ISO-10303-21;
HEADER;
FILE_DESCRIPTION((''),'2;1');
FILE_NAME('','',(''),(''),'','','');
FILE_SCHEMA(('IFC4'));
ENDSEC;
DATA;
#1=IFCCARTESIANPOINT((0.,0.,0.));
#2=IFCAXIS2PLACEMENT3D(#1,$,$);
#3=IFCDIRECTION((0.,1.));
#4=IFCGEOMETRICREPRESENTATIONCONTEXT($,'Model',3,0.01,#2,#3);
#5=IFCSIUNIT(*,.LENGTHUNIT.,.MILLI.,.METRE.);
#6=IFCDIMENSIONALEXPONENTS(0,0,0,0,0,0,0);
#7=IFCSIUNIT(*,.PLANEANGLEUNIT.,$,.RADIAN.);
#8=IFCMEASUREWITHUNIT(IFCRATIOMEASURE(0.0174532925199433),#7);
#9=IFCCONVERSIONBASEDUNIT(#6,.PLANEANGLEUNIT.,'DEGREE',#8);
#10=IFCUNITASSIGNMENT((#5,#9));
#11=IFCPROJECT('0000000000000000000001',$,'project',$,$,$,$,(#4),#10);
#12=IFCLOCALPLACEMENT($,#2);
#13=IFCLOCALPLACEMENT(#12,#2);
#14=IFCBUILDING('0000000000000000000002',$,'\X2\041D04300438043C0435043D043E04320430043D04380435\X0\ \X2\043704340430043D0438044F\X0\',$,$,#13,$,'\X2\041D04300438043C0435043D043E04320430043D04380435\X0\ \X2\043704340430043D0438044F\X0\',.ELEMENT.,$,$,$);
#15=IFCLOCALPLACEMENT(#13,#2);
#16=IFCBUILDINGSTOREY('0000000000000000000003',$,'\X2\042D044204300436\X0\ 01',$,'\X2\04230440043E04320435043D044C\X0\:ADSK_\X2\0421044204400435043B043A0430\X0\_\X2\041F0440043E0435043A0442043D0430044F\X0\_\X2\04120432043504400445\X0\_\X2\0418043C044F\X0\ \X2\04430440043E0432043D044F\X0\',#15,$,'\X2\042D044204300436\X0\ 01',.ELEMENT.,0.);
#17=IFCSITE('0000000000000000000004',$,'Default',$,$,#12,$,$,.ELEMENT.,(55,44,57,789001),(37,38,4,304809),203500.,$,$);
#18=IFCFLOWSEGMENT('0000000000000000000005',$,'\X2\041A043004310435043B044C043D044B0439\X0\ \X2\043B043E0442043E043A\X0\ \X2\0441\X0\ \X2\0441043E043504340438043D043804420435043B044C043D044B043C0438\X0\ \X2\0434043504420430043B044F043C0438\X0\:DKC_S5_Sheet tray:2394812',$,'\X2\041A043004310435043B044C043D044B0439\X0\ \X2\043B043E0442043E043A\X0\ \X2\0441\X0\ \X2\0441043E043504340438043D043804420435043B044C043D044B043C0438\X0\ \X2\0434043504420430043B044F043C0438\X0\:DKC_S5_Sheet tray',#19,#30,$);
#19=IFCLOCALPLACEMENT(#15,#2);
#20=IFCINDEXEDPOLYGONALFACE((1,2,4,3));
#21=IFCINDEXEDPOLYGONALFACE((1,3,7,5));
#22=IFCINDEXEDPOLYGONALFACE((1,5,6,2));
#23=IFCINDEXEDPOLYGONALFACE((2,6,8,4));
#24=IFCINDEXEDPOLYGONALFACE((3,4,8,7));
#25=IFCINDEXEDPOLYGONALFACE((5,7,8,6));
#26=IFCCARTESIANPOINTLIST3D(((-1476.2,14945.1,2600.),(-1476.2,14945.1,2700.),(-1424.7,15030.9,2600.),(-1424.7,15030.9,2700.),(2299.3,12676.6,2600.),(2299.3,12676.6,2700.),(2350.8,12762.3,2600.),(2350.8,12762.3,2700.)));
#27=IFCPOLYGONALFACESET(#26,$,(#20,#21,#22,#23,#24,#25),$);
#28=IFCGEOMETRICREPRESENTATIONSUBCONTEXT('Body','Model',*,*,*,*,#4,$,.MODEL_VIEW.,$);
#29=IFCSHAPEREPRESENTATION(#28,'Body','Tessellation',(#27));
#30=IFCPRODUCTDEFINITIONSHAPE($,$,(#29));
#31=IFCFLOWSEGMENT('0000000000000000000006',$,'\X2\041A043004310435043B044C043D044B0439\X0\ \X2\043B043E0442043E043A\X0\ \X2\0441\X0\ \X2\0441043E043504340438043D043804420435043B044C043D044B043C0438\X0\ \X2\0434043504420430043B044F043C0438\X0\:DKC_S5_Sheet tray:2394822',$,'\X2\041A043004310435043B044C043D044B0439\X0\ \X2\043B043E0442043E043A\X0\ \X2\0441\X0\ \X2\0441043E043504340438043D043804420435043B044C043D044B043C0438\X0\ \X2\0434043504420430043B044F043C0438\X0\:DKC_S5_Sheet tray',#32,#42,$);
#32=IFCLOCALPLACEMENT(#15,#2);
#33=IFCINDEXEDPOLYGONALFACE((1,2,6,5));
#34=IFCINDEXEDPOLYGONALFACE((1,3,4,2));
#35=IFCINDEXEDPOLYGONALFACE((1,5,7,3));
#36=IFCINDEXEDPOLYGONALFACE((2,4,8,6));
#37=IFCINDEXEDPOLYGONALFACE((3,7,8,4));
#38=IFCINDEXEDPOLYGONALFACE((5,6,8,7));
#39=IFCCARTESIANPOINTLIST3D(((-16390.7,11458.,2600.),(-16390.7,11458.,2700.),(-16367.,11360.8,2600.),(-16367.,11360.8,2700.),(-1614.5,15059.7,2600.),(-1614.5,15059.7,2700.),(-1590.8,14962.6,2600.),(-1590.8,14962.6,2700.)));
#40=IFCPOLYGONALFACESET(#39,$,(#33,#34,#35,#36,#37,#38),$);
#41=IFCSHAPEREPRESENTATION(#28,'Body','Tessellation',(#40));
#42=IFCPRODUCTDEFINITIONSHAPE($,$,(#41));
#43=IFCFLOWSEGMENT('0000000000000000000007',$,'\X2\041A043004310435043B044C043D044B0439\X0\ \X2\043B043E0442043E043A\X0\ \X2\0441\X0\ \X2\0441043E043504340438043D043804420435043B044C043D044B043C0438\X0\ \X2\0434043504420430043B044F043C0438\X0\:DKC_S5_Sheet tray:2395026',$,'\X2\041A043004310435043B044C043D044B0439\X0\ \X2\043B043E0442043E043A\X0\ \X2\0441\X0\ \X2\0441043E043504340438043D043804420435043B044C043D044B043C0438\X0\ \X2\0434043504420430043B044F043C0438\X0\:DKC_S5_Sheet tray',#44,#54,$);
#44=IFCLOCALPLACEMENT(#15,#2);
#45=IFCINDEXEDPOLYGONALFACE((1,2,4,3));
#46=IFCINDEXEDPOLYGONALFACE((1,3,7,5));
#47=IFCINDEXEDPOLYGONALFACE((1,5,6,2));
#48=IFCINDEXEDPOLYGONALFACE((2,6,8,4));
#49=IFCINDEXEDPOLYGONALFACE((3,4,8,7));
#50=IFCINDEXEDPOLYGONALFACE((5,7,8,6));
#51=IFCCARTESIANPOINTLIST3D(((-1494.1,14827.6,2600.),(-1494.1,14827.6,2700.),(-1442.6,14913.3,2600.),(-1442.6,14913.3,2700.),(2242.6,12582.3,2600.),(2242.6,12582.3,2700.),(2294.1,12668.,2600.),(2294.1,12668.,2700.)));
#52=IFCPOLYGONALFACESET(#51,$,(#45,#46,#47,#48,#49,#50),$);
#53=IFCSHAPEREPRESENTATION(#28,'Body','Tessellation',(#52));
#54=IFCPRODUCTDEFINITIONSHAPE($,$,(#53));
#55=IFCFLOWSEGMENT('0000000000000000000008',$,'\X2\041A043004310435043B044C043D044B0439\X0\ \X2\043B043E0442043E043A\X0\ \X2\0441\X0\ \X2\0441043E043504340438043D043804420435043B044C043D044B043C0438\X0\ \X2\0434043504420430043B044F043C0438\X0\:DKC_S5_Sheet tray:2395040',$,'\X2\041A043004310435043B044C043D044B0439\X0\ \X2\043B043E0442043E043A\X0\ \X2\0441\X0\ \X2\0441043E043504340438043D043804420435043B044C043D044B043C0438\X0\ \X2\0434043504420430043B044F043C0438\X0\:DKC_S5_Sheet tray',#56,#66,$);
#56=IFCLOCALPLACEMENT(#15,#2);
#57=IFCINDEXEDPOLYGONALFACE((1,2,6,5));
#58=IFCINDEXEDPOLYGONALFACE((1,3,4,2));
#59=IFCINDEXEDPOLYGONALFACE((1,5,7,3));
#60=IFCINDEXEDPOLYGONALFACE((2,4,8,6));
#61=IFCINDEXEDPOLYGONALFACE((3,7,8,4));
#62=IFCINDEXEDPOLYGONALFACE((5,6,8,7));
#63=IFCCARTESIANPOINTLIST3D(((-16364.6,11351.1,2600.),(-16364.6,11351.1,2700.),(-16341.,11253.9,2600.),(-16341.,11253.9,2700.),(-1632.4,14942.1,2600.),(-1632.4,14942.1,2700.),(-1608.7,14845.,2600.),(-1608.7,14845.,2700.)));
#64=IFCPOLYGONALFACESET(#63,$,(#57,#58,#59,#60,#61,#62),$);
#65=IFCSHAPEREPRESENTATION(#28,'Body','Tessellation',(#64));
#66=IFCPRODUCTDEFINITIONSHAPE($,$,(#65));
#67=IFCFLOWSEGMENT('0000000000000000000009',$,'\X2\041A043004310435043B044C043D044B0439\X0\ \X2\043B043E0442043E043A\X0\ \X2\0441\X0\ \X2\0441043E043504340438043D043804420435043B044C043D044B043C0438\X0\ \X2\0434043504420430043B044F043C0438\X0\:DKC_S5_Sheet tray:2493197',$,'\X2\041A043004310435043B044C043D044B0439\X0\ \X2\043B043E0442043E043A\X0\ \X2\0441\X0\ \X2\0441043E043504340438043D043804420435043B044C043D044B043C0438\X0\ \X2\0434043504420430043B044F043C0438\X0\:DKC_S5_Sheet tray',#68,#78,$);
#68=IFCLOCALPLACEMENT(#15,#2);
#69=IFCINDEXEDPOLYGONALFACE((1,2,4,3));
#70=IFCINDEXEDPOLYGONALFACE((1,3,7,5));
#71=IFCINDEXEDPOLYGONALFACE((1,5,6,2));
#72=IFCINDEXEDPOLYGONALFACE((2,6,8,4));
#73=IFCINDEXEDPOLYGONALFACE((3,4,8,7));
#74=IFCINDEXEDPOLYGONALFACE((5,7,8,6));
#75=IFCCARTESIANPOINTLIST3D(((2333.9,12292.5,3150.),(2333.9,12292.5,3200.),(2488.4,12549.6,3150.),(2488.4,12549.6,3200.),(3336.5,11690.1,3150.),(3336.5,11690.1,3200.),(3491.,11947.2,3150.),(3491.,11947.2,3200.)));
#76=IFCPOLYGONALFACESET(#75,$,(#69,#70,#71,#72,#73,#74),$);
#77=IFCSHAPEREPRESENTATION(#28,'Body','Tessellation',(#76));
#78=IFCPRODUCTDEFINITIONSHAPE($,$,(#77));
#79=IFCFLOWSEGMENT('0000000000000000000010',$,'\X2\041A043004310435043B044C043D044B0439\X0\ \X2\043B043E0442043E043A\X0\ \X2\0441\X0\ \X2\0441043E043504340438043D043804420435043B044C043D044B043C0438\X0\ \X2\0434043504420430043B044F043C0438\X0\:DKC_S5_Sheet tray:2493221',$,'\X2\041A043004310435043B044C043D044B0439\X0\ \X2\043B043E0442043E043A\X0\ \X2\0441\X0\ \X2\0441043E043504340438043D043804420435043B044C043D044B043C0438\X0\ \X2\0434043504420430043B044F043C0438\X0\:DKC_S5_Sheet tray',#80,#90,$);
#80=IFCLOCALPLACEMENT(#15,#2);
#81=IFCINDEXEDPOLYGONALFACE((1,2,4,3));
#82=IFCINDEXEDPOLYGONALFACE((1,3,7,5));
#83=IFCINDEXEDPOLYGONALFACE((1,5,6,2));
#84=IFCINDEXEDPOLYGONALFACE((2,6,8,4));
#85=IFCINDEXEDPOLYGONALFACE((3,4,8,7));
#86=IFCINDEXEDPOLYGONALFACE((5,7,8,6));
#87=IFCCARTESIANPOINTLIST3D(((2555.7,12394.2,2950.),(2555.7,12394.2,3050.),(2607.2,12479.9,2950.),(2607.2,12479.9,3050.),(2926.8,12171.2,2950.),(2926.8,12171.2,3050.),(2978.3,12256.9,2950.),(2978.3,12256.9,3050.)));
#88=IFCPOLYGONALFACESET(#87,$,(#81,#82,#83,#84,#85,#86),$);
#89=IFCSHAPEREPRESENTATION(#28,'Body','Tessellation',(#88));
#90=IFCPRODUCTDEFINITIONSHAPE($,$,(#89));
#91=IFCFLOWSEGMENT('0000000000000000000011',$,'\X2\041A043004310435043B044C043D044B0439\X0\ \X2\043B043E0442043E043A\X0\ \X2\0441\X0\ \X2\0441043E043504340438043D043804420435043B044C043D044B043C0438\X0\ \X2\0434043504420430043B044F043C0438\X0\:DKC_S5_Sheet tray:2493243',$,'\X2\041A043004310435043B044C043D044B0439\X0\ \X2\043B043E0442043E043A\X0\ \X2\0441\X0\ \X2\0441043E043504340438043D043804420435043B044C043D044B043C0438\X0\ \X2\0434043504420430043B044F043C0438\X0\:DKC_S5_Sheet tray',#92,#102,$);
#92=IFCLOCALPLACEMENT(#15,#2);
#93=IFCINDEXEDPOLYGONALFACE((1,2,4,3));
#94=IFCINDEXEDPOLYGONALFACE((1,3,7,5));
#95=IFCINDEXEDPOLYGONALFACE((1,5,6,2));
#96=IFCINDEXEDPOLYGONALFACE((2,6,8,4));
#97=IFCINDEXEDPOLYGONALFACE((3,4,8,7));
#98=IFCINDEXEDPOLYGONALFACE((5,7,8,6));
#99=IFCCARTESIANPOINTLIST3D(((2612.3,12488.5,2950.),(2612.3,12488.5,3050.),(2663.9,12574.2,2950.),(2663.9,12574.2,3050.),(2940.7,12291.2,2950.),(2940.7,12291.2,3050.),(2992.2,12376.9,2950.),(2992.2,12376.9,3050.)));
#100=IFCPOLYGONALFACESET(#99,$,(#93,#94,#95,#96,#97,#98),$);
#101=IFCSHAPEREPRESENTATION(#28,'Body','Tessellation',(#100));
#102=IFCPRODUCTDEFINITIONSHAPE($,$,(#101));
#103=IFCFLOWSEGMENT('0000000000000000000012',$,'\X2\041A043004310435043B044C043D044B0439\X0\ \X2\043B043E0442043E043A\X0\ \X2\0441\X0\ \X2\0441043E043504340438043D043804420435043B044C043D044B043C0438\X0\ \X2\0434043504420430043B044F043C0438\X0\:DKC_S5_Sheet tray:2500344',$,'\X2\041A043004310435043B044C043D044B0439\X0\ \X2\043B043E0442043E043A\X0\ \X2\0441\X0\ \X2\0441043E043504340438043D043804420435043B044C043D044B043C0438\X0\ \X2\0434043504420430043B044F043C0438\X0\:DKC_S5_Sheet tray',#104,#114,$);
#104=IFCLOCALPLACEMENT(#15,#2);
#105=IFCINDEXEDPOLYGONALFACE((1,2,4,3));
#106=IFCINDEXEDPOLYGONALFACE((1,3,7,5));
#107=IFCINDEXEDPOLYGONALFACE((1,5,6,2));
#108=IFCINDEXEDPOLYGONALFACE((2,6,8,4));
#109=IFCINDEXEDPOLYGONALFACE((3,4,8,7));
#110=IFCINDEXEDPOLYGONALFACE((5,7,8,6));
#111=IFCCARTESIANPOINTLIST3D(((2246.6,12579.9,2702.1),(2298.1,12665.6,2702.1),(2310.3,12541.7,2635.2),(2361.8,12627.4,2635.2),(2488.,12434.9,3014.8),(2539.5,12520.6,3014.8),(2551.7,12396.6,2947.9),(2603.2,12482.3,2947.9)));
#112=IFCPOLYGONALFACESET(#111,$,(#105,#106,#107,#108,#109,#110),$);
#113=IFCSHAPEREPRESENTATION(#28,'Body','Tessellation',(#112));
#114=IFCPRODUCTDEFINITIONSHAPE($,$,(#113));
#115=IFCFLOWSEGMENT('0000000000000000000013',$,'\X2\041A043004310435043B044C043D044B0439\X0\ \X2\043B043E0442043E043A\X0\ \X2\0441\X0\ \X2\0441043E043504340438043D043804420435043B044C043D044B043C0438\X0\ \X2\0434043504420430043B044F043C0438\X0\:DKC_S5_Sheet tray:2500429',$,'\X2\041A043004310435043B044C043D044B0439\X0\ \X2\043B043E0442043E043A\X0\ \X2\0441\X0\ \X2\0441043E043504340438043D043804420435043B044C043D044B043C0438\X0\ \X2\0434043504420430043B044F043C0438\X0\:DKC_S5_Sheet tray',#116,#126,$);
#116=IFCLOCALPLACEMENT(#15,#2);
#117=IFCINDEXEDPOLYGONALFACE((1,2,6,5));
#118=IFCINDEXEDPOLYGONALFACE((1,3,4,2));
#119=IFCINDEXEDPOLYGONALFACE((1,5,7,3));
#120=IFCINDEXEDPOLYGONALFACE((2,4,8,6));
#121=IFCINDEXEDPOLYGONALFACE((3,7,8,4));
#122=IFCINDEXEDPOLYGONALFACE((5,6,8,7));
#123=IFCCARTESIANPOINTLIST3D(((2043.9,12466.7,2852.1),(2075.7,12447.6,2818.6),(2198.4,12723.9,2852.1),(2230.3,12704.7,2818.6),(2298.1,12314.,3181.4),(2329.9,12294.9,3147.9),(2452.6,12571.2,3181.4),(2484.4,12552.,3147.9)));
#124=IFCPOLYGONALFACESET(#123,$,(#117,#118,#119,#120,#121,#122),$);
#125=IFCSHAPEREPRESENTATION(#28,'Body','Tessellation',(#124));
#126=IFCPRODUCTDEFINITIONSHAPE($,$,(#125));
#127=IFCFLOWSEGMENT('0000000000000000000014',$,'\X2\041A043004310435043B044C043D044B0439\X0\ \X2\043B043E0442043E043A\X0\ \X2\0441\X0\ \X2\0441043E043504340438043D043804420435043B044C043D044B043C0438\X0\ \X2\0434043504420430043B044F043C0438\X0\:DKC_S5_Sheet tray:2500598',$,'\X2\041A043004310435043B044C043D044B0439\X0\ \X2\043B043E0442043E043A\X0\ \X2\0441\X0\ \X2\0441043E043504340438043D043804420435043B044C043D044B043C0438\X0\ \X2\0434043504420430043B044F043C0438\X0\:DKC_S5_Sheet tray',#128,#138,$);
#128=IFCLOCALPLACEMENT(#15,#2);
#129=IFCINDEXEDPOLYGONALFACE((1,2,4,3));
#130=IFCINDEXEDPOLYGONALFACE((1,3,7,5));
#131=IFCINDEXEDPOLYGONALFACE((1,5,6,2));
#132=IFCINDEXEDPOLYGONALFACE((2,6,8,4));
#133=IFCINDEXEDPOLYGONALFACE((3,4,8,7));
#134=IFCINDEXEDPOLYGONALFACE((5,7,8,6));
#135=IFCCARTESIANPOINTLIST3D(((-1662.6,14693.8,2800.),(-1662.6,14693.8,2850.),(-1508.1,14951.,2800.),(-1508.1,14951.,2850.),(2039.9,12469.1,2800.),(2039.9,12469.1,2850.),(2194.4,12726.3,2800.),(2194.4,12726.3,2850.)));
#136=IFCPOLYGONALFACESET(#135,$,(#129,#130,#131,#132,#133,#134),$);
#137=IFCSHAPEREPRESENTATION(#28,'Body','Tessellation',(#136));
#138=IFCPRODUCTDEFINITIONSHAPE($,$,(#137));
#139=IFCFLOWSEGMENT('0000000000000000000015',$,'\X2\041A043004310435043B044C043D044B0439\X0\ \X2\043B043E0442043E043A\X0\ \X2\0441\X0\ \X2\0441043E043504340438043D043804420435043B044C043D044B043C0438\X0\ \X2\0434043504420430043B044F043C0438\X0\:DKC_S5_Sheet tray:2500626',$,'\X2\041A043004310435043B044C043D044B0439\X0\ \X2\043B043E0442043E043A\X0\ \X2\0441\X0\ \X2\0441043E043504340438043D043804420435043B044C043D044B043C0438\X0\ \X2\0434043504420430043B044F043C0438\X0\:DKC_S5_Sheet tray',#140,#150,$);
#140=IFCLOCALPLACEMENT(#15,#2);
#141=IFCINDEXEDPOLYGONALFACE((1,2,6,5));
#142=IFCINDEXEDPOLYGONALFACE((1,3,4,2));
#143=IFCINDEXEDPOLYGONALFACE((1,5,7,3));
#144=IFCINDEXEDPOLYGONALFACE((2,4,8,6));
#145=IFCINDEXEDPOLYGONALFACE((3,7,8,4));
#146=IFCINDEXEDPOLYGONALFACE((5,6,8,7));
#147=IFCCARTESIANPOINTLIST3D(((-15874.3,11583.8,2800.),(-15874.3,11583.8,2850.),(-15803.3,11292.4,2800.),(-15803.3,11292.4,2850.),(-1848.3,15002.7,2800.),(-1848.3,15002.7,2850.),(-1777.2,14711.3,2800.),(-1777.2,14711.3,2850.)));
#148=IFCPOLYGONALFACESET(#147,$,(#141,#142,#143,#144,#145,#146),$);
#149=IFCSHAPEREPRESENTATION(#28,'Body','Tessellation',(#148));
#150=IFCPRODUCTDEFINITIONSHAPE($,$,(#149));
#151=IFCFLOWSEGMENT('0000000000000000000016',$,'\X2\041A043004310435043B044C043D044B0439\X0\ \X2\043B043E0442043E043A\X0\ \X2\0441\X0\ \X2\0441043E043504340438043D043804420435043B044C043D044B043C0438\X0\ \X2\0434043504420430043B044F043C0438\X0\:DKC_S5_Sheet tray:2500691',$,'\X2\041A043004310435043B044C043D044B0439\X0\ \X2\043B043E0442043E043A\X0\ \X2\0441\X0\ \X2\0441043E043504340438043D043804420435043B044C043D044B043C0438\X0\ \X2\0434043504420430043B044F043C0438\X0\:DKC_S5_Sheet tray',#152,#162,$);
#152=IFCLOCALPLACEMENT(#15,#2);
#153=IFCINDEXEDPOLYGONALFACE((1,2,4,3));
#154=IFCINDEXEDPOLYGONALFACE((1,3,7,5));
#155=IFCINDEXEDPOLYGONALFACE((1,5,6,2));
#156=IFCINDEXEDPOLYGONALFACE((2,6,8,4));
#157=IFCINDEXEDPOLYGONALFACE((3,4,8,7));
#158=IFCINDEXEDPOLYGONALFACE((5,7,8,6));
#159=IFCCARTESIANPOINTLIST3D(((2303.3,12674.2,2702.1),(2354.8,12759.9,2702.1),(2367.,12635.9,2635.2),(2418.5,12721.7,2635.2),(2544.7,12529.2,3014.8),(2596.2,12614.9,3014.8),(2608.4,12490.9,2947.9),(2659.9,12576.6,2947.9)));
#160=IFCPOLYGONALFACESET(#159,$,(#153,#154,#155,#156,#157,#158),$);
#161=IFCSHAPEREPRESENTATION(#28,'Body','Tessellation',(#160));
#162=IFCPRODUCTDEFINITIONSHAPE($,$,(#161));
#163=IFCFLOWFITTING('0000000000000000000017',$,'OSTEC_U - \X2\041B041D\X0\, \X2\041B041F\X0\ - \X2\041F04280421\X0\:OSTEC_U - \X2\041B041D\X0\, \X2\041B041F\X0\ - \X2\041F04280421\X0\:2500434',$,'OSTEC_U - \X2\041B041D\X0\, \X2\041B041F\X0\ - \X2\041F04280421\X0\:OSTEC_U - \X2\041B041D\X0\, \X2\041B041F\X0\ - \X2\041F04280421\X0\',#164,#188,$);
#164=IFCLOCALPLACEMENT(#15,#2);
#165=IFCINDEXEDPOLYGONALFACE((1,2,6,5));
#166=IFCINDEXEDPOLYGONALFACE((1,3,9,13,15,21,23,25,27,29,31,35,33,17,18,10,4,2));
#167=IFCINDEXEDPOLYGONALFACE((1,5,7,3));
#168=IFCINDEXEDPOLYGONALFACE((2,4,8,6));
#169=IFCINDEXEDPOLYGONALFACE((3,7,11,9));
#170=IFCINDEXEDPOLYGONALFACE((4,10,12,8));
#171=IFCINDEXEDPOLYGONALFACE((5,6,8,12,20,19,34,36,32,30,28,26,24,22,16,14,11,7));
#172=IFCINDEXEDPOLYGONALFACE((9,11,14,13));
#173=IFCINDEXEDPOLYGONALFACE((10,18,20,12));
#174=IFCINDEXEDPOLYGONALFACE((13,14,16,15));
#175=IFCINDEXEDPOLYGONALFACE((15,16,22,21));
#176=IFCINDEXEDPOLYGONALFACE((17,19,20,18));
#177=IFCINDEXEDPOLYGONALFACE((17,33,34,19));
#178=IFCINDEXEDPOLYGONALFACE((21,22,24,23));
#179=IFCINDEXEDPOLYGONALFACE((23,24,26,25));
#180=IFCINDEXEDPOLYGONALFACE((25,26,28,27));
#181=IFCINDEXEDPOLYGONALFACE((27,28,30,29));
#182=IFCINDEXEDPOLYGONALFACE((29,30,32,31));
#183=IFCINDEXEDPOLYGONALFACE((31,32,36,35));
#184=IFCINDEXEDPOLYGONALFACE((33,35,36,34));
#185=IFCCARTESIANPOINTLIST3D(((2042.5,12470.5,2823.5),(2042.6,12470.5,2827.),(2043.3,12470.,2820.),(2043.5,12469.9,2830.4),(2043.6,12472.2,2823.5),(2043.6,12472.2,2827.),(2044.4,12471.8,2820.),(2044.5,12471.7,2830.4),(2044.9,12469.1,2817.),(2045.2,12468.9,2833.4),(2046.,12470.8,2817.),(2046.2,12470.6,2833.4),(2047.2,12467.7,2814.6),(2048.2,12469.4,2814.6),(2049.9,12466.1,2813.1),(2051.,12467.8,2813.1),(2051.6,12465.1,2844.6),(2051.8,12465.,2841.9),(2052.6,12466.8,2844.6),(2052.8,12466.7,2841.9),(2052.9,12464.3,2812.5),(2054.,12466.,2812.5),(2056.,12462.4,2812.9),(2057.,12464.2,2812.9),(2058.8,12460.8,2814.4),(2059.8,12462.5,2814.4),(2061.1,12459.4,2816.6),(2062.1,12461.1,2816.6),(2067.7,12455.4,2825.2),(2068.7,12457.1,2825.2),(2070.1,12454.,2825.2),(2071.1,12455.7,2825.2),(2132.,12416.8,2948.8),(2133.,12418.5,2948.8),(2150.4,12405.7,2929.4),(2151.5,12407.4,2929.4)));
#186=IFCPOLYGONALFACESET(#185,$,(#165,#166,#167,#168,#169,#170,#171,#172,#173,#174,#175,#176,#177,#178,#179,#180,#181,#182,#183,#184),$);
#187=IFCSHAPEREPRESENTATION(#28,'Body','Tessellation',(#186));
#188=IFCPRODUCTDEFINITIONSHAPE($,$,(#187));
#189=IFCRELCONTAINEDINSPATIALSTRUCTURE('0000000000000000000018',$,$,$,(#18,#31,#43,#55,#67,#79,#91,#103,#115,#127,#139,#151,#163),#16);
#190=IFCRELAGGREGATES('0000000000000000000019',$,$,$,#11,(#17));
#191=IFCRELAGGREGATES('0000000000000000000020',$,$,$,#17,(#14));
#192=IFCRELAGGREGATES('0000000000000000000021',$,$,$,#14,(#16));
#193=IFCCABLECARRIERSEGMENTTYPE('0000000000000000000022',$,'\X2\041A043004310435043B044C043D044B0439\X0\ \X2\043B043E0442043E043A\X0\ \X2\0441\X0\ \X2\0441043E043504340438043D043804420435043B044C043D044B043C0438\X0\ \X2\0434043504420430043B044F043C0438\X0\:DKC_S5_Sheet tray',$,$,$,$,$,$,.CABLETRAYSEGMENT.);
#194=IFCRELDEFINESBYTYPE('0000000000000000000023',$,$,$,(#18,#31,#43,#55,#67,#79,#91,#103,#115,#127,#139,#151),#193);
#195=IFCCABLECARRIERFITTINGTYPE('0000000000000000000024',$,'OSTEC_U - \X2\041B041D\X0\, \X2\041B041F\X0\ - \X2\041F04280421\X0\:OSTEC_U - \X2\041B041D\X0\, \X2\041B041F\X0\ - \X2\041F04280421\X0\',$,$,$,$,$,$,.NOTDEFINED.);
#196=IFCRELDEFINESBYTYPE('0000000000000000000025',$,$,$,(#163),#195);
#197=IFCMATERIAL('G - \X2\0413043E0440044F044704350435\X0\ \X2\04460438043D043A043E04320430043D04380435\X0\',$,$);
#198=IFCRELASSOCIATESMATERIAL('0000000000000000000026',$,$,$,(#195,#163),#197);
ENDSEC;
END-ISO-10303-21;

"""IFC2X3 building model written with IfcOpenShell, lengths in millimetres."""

from ifc_helpers import new_model, entity, si_unit, converted_unit, direction, frame, frame_2d, origin, origin_2d_with_axis, place, context, subcontext, project, spatial, polyline, circle_curve, parameter, trimmed, segment, composite_curve, rectangle, outline, extrude, source, transform, mapped, material, type_object, type_shapes, element, save


model = new_model("IFC2X3")

# Units and contexts
model_context = context("Model", 3, precision=0.01, world=origin(), true_north=direction((0.0, 1.0)))
body_context = subcontext(model_context, "Body", "Model", "MODEL_VIEW")
ifc_project = project(units=[si_unit("LENGTHUNIT", "METRE", prefix="MILLI"), converted_unit("PLANEANGLEUNIT", "DEGREE", entity("IfcRatioMeasure", 0.0174532925199433), si_unit("PLANEANGLEUNIT", "RADIAN"), dimensions=[0, 0, 0, 0, 0, 0, 0])], contexts=[model_context])

# Site, building, storey
site_placement = place(None, frame((0.0, 0.0, 0.0)))
site = spatial("IfcSite", under=ifc_project, at=site_placement, Name="Default", CompositionType="ELEMENT", RefLatitude=(55, 44, 57, 789001), RefLongitude=(37, 38, 4, 304809), RefElevation=203500.0)
building_placement = place(site_placement, origin())
building = spatial("IfcBuilding", under=site, at=building_placement, Name="Наименование здания", LongName="Наименование здания", CompositionType="ELEMENT")
storey_placement = place(building_placement, origin())
storey = spatial("IfcBuildingStorey", under=building, at=storey_placement, Name="Этаж 01", ObjectType="Уровень:ADSK_Стрелка_Проектная_Вверх_Имя уровня", LongName="Этаж 01", CompositionType="ELEMENT", Elevation=0.0)

# Flow segments
cable_carrier_segment_type = type_object("IfcCableCarrierSegmentType", Name="Кабельный лоток с соединительными деталями:DKC_S5_Sheet tray", PredefinedType="CABLETRAYSEGMENT")
flow_segment_1_placement = place(storey_placement, frame((-1476.2, 12676.6, 2600.0)))
element("IfcFlowSegment", 1, at=flow_segment_1_placement, inside=storey, type_object=cable_carrier_segment_type, Name="Кабельный лоток с соединительными деталями:DKC_S5_Sheet tray:2394812", ObjectType="Кабельный лоток с соединительными деталями:DKC_S5_Sheet tray", context=body_context, shape_type="SweptSolid", body=[
    extrude(rectangle(XDim=4404.6, YDim=100.0, at=frame_2d((0.0, 0.0), x_axis=(1.0, 0.0))), frame((1913.5, 1177.1, 0.0), z_axis=(0.0, 0.0, 1.0), x_axis=(0.857167, -0.515038, 0.0)), (0.0, 0.0, 1.0), 100.0),
])
flow_segment_2_placement = place(storey_placement, frame((-16390.7, 11360.8, 2600.0)))
element("IfcFlowSegment", 2, at=flow_segment_2_placement, inside=storey, type_object=cable_carrier_segment_type, Name="Кабельный лоток с соединительными деталями:DKC_S5_Sheet tray:2394822", ObjectType="Кабельный лоток с соединительными деталями:DKC_S5_Sheet tray", context=body_context, shape_type="SweptSolid", body=[
    extrude(rectangle(XDim=15208.9, YDim=100.0, at=origin_2d_with_axis()), frame((7400.0, 1849.5, 0.0), z_axis=(0.0, 0.0, 1.0), x_axis=(-0.971553, -0.236821, 0.0)), (0.0, 0.0, 1.0), 100.0),
])
flow_segment_3_placement = place(storey_placement, frame((-1494.1, 12582.3, 2600.0)))
element("IfcFlowSegment", 3, at=flow_segment_3_placement, inside=storey, type_object=cable_carrier_segment_type, Name="Кабельный лоток с соединительными деталями:DKC_S5_Sheet tray:2395026", ObjectType="Кабельный лоток с соединительными деталями:DKC_S5_Sheet tray", context=body_context, shape_type="SweptSolid", body=[
    extrude(rectangle(XDim=4359.4, YDim=100.0, at=frame_2d((0.0, 0.0), x_axis=(1.0, 0.0))), frame((1894.1, 1165.5, 0.0), z_axis=(0.0, 0.0, 1.0), x_axis=(0.857167, -0.515038, 0.0)), (0.0, 0.0, 1.0), 100.0),
])
flow_segment_4_placement = place(storey_placement, frame((-16364.6, 11253.9, 2600.0)))
element("IfcFlowSegment", 4, at=flow_segment_4_placement, inside=storey, type_object=cable_carrier_segment_type, Name="Кабельный лоток с соединительными деталями:DKC_S5_Sheet tray:2395040", ObjectType="Кабельный лоток с соединительными деталями:DKC_S5_Sheet tray", context=body_context, shape_type="SweptSolid", body=[
    extrude(rectangle(XDim=15163.6, YDim=100.0, at=frame_2d((0.0, 0.0), x_axis=(1.0, 0.0))), frame((7378.0, 1844.1, 0.0), z_axis=(0.0, 0.0, 1.0), x_axis=(-0.971553, -0.236821, 0.0)), (0.0, 0.0, 1.0), 100.0),
])
flow_segment_5_placement = place(storey_placement, frame((2333.9, 11690.1, 3150.0)))
element("IfcFlowSegment", 5, at=flow_segment_5_placement, inside=storey, type_object=cable_carrier_segment_type, Name="Кабельный лоток с соединительными деталями:DKC_S5_Sheet tray:2493197", ObjectType="Кабельный лоток с соединительными деталями:DKC_S5_Sheet tray", context=body_context, shape_type="SweptSolid", body=[
    extrude(rectangle(XDim=1169.7, YDim=300.0, at=frame_2d((0.0, 0.0), x_axis=(1.0, 0.0))), frame((578.6, 429.8, 0.0), z_axis=(0.0, 0.0, 1.0), x_axis=(-0.857167, 0.515038, 0.0)), (0.0, 0.0, 1.0), 50.0),
])
flow_segment_6_placement = place(storey_placement, frame((2555.7, 12171.2, 2950.0)))
element("IfcFlowSegment", 6, at=flow_segment_6_placement, inside=storey, type_object=cable_carrier_segment_type, Name="Кабельный лоток с соединительными деталями:DKC_S5_Sheet tray:2493221", ObjectType="Кабельный лоток с соединительными деталями:DKC_S5_Sheet tray", context=body_context, shape_type="SweptSolid", body=[
    extrude(rectangle(XDim=433.0, YDim=100.0, at=frame_2d((0.0, 0.0), x_axis=(1.0, 0.0))), frame((211.3, 154.4, 0.0), z_axis=(0.0, 0.0, 1.0), x_axis=(-0.857167, 0.515038, 0.0)), (0.0, 0.0, 1.0), 100.0),
])
flow_segment_7_placement = place(storey_placement, frame((2612.3, 12291.2, 2950.0)))
element("IfcFlowSegment", 7, at=flow_segment_7_placement, inside=storey, type_object=cable_carrier_segment_type, Name="Кабельный лоток с соединительными деталями:DKC_S5_Sheet tray:2493243", ObjectType="Кабельный лоток с соединительными деталями:DKC_S5_Sheet tray", context=body_context, shape_type="SweptSolid", body=[
    extrude(rectangle(XDim=383.0, YDim=100.0, at=origin_2d_with_axis()), frame((189.9, 141.5, 0.0), z_axis=(0.0, 0.0, 1.0), x_axis=(-0.857167, 0.515038, 0.0)), (0.0, 0.0, 1.0), 100.0),
])
flow_segment_8_placement = place(storey_placement, frame((2246.6, 12396.6, 2635.2)))
element("IfcFlowSegment", 8, at=flow_segment_8_placement, inside=storey, type_object=cable_carrier_segment_type, Name="Кабельный лоток с соединительными деталями:DKC_S5_Sheet tray:2500344", ObjectType="Кабельный лоток с соединительными деталями:DKC_S5_Sheet tray", context=body_context, shape_type="SweptSolid", body=[
    extrude(rectangle(XDim=100.0, YDim=100.0, at=frame_2d((0.0, 0.0), x_axis=(0.0, 1.0))), frame((57.6, 207.0, 33.5), z_axis=(0.573557, -0.344628, 0.743145), x_axis=(-0.515038, -0.857167, 0.0)), (0.0, 0.0, 1.0), 420.9),
])
flow_segment_9_placement = place(storey_placement, frame((2043.9, 12294.9, 2818.6)))
element("IfcFlowSegment", 9, at=flow_segment_9_placement, inside=storey, type_object=cable_carrier_segment_type, Name="Кабельный лоток с соединительными деталями:DKC_S5_Sheet tray:2500429", ObjectType="Кабельный лоток с соединительными деталями:DKC_S5_Sheet tray", context=body_context, shape_type="SweptSolid", body=[
    extrude(rectangle(XDim=50.0, YDim=300.0, at=frame_2d((0.0, 0.0), x_axis=(0.0, 1.0))), frame((93.2, 290.9, 16.7), z_axis=(0.573557, -0.344628, 0.743145), x_axis=(0.515038, 0.857167, 0.0)), (0.0, 0.0, 1.0), 443.1),
])
flow_segment_10_placement = place(storey_placement, frame((-1662.6, 12469.1, 2800.0)))
element("IfcFlowSegment", 10, at=flow_segment_10_placement, inside=storey, type_object=cable_carrier_segment_type, Name="Кабельный лоток с соединительными деталями:DKC_S5_Sheet tray:2500598", ObjectType="Кабельный лоток с соединительными деталями:DKC_S5_Sheet tray", context=body_context, shape_type="SweptSolid", body=[
    extrude(rectangle(XDim=4319.5, YDim=300.0, at=frame_2d((0.0, 0.0), x_axis=(1.0, 0.0))), frame((1928.5, 1240.9, 0.0), z_axis=(0.0, 0.0, 1.0), x_axis=(-0.857167, 0.515038, 0.0)), (0.0, 0.0, 1.0), 50.0),
])
flow_segment_11_placement = place(storey_placement, frame((-15874.3, 11292.4, 2800.0)))
element("IfcFlowSegment", 11, at=flow_segment_11_placement, inside=storey, type_object=cable_carrier_segment_type, Name="Кабельный лоток с соединительными деталями:DKC_S5_Sheet tray:2500626", ObjectType="Кабельный лоток с соединительными деталями:DKC_S5_Sheet tray", context=body_context, shape_type="SweptSolid", body=[
    extrude(rectangle(XDim=14436.7, YDim=300.0, at=frame_2d((0.0, 0.0), x_axis=(1.0, 0.0))), frame((7048.5, 1855.2, 0.0), z_axis=(0.0, 0.0, 1.0), x_axis=(-0.971553, -0.236821, 0.0)), (0.0, 0.0, 1.0), 50.0),
])
flow_segment_12_placement = place(storey_placement, frame((2303.3, 12490.9, 2635.2)))
element("IfcFlowSegment", 12, at=flow_segment_12_placement, inside=storey, type_object=cable_carrier_segment_type, Name="Кабельный лоток с соединительными деталями:DKC_S5_Sheet tray:2500691", ObjectType="Кабельный лоток с соединительными деталями:DKC_S5_Sheet tray", context=body_context, shape_type="SweptSolid", body=[
    extrude(rectangle(XDim=100.0, YDim=100.0, at=frame_2d((0.0, 0.0), x_axis=(0.0, 1.0))), frame((57.6, 207.0, 33.5), z_axis=(0.573557, -0.344628, 0.743145), x_axis=(-0.515038, -0.857167, 0.0)), (0.0, 0.0, 1.0), 420.9),
])

# Flow fitting
ifc_material_1 = material(Name="G - Горячее цинкование")
cable_carrier_fitting_type_1 = type_object("IfcCableCarrierFittingType", Name="OSTEC_U - ЛН, ЛП - ПШС:OSTEC_U - ЛН, ЛП - ПШС", PredefinedType="NOTDEFINED", material=ifc_material_1)
shared_shape_1 = source(origin(), body_context, "Body", "SweptSolid", [
    extrude(outline(composite_curve([segment(trimmed(circle_curve(frame_2d((-44.6, 0.0), x_axis=(1.0, 0.0)), 12.5), [parameter(90.0)], [parameter(270.0)], True, "PARAMETER"), True, "CONTINUOUS"), segment(polyline([(-44.6, -12.5), (-33.1, -12.5)]), True, "CONTINUOUS"), segment(polyline([(-33.1, -12.5), (-31.2, -14.5)]), True, "CONTINUOUS"), segment(polyline([(-31.2, -14.5), (108.9, -14.5)]), True, "CONTINUOUS"), segment(polyline([(108.9, -14.5), (108.9, 14.5)]), True, "CONTINUOUS"), segment(polyline([(108.9, 14.5), (-31.2, 14.5)]), True, "CONTINUOUS"), segment(polyline([(-31.2, 14.5), (-33.1, 12.5)]), True, "CONTINUOUS"), segment(polyline([(-33.1, 12.5), (-44.6, 12.5)]), True, "CONTINUOUS")], self_intersect=False)), frame((44.6, 0.0, 0.0), z_axis=(0.0, 0.0, -1.0), x_axis=(1.0, 0.0, 0.0)), (0.0, 0.0, -1.0), 2.0),
])
type_shapes(cable_carrier_fitting_type_1, [shared_shape_1])
for number, where, z_axis, x_axis, name in (
    (13, (2054.2, 12465.9, 2825.0), (-0.515038, -0.857167, 0.0), (0.573557, -0.344628, 0.743145), "OSTEC_U - ЛН, ЛП - ПШС:OSTEC_U - ЛН, ЛП - ПШС:2500434"),
):
    element("IfcFlowFitting", number, at=place(storey_placement, frame(where, z_axis=z_axis, x_axis=x_axis)), inside=storey, type_object=cable_carrier_fitting_type_1, material=ifc_material_1, Name=name, ObjectType="OSTEC_U - ЛН, ЛП - ПШС:OSTEC_U - ЛН, ЛП - ПШС", context=body_context, shape_type="MappedRepresentation", body=[
        mapped(shared_shape_1, transform((0.0, 0.0, 0.0), scale=1.0)),
    ])

save(model, "model.ifc")
